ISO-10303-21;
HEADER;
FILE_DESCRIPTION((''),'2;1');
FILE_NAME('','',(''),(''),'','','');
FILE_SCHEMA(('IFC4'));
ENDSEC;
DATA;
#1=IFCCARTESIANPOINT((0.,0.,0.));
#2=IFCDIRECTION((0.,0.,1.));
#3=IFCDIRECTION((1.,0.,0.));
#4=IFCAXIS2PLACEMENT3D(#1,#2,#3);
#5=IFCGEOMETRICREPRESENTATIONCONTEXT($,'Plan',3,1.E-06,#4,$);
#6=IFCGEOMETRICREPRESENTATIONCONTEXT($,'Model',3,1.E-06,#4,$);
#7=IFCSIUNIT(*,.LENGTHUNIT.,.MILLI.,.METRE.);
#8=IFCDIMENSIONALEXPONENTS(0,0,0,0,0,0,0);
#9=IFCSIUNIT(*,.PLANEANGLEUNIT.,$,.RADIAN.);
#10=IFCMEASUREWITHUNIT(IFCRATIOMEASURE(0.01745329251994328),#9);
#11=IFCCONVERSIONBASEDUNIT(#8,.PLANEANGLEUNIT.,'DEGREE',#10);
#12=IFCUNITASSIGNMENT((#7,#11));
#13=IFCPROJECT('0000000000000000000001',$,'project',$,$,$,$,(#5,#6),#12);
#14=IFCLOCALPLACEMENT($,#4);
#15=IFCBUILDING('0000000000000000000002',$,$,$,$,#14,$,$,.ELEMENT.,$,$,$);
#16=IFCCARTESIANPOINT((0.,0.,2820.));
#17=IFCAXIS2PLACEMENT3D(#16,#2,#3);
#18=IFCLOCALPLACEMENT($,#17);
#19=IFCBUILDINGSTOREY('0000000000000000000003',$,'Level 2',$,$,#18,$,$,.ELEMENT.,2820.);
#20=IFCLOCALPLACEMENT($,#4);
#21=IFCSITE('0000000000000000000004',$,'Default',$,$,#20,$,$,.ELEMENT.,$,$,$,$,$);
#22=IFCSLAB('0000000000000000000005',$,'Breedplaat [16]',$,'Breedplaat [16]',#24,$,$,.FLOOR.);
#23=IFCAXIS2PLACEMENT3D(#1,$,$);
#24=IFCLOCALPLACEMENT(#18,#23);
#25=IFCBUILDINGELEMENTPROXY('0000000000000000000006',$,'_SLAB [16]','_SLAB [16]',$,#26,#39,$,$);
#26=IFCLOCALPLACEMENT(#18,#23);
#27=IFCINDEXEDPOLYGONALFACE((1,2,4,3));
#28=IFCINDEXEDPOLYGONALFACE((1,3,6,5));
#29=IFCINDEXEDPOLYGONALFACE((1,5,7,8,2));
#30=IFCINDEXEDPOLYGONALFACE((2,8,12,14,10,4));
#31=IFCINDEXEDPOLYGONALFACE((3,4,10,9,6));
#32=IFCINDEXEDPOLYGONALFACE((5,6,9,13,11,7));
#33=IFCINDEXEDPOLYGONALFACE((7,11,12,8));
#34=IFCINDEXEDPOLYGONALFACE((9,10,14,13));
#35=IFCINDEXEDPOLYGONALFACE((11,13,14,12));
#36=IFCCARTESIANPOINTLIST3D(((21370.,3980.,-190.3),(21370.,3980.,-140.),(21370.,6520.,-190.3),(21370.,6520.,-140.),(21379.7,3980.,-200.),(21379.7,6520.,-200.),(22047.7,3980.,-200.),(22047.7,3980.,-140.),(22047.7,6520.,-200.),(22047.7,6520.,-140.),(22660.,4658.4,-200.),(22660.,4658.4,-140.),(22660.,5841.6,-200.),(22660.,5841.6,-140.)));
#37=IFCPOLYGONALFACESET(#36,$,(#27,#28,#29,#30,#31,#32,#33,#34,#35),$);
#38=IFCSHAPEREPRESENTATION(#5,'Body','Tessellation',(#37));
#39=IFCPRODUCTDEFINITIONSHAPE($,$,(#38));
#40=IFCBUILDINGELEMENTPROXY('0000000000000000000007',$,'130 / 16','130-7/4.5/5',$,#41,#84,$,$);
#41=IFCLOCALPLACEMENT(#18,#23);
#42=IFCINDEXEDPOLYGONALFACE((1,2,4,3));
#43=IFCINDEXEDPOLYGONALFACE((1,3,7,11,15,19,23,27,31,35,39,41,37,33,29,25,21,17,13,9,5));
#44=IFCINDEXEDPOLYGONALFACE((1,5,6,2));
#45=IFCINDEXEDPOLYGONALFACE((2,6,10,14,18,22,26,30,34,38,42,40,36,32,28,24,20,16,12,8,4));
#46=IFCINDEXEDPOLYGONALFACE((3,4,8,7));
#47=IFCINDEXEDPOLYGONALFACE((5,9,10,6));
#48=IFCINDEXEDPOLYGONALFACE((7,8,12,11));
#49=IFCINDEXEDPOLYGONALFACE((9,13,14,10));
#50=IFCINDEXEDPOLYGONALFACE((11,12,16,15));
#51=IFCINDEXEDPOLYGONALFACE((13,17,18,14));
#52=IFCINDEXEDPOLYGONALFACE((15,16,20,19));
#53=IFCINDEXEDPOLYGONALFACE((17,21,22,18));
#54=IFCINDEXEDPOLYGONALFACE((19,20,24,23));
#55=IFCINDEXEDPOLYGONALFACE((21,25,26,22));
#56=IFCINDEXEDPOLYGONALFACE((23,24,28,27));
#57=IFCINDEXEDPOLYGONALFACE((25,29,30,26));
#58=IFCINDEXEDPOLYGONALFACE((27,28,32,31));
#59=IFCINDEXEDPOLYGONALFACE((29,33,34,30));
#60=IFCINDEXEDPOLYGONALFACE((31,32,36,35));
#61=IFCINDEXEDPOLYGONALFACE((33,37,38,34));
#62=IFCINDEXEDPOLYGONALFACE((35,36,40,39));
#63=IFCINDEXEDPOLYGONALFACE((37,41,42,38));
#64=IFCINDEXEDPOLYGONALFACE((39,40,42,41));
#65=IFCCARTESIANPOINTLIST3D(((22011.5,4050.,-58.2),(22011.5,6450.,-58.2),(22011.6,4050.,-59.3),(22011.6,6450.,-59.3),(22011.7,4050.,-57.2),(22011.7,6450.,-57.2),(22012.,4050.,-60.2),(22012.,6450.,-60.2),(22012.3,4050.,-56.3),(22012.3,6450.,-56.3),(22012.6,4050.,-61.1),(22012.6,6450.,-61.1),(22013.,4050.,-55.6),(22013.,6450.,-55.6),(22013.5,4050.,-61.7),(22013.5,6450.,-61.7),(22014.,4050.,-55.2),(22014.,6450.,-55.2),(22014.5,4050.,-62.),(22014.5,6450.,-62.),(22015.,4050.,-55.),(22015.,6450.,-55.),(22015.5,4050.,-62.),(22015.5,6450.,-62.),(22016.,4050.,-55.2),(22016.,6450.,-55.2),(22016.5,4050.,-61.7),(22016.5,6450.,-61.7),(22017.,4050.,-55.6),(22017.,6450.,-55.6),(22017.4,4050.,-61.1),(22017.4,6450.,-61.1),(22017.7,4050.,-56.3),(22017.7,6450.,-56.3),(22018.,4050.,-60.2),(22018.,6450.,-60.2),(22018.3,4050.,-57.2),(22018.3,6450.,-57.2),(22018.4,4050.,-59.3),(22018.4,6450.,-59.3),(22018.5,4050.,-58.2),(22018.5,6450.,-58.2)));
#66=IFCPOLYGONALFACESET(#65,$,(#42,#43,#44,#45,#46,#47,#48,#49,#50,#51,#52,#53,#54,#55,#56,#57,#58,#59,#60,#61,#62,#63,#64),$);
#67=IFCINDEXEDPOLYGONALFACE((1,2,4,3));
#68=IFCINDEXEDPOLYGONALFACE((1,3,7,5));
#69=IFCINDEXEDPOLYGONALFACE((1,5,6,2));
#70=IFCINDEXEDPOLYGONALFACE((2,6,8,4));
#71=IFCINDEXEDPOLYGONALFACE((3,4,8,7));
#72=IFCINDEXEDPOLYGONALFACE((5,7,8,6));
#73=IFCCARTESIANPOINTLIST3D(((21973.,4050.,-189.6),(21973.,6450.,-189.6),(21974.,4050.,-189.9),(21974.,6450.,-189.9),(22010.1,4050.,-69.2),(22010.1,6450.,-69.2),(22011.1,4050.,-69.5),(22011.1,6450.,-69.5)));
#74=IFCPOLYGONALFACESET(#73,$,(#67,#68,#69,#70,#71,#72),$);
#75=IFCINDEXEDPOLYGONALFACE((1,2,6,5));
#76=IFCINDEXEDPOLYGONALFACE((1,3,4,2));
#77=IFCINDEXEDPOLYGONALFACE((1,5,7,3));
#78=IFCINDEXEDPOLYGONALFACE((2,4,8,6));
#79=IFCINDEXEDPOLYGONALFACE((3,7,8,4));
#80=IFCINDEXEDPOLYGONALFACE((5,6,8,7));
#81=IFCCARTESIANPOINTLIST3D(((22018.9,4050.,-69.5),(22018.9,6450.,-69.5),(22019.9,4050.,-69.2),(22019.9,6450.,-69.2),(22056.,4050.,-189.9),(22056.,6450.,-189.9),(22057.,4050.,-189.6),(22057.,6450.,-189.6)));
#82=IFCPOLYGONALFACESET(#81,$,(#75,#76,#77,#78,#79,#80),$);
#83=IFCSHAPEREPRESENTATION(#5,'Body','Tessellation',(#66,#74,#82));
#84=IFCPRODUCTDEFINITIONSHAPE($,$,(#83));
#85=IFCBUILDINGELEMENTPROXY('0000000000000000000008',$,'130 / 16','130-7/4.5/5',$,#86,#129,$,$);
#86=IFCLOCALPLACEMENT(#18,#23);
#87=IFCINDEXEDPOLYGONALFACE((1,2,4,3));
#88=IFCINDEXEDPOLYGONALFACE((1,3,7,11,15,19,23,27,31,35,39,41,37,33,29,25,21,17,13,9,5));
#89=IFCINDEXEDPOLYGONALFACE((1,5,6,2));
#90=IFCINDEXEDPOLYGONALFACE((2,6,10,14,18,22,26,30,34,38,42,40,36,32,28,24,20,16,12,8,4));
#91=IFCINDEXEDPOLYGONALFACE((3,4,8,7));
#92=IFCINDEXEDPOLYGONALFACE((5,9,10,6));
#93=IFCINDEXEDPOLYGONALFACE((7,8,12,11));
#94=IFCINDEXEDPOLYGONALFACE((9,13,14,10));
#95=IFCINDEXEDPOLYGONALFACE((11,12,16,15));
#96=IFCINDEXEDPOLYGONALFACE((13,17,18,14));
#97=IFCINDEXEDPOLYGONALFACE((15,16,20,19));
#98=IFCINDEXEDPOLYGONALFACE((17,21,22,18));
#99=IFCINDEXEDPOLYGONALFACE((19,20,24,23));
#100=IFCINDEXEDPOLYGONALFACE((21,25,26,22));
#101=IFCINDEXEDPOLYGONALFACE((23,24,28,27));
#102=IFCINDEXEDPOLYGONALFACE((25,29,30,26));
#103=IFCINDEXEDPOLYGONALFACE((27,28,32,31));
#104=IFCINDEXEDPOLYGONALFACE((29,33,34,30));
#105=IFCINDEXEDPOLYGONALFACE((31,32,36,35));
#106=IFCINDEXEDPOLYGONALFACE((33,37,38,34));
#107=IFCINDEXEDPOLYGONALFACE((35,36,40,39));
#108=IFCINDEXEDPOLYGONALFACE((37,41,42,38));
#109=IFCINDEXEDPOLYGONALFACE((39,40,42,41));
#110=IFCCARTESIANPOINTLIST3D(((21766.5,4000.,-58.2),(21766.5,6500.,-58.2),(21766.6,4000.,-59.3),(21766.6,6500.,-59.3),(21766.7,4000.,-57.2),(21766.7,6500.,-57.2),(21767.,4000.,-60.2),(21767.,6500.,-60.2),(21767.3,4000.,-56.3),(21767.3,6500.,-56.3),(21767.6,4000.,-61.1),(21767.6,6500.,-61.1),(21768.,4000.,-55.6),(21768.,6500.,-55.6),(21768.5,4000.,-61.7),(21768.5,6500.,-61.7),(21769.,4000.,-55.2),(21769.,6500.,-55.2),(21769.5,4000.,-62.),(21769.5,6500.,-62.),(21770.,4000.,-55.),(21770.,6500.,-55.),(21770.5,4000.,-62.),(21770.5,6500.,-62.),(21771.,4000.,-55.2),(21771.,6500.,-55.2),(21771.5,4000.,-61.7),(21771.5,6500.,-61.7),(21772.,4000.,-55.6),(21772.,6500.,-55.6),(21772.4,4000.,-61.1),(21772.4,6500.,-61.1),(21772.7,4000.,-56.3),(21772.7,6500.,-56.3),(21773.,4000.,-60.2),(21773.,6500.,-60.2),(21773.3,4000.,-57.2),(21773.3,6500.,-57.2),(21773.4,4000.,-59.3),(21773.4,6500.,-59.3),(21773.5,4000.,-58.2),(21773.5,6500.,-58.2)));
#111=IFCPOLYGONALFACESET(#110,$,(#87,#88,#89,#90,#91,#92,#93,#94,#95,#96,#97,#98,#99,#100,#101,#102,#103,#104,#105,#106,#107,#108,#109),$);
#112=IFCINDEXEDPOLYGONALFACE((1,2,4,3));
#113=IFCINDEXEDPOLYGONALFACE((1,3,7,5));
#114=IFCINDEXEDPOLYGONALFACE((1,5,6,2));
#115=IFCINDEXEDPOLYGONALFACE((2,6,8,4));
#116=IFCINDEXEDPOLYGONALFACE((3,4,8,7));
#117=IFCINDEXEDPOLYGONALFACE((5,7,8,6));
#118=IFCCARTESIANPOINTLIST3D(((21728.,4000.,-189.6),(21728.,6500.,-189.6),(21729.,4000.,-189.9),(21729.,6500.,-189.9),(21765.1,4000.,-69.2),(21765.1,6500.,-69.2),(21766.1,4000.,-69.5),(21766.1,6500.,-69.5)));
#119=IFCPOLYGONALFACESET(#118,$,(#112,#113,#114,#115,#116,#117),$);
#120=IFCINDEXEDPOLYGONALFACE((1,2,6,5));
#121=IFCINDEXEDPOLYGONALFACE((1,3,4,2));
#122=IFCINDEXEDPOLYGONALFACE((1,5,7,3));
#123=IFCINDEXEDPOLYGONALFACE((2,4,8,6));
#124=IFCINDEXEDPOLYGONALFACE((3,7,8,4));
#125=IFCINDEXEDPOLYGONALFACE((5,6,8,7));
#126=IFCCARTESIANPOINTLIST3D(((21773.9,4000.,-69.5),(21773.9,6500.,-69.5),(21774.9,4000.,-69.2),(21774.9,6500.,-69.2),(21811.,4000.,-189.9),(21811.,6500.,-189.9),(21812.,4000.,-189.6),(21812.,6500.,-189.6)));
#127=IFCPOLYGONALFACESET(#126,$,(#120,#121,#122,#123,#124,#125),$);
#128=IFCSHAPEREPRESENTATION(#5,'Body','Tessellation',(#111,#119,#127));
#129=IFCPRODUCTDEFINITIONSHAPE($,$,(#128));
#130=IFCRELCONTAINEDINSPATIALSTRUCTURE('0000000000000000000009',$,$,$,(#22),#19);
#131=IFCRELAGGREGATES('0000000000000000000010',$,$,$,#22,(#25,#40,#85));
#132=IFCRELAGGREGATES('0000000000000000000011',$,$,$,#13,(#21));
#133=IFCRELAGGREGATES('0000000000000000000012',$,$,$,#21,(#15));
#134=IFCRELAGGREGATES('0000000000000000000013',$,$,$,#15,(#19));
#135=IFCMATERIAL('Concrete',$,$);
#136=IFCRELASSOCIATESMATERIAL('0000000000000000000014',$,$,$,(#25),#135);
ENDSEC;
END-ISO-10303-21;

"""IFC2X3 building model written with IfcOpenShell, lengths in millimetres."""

from ifc_helpers import new_model, entity, si_unit, converted_unit, frame, origin_with_axes, origin_2d_with_axis, place, context, project, spatial, polyline, rectangle, circle, outline, extrude, material, element, aggregate, save


model = new_model("IFC2X3")

# Units and contexts
plan_context = context("Plan", 3, precision=1e-06, world=origin_with_axes())
model_context = context("Model", 3, precision=1e-06, world=origin_with_axes())
ifc_project = project(units=[si_unit("LENGTHUNIT", "METRE", prefix="MILLI"), converted_unit("PLANEANGLEUNIT", "DEGREE", entity("IfcRatioMeasure", 0.01745329251994328), si_unit("PLANEANGLEUNIT", "RADIAN"), dimensions=[0, 0, 0, 0, 0, 0, 0])], contexts=[plan_context, model_context])

# Site, building, storey
site_placement = place(None, origin_with_axes())
site = spatial("IfcSite", under=ifc_project, at=site_placement, Name="Default", CompositionType="ELEMENT")
building_placement = place(None, origin_with_axes())
building = spatial("IfcBuilding", under=site, at=building_placement, CompositionType="ELEMENT")
storey_placement = place(None, frame((0.0, 0.0, 2820.0), z_axis=(0.0, 0.0, 1.0), x_axis=(1.0, 0.0, 0.0)))
storey = spatial("IfcBuildingStorey", under=building, at=storey_placement, Name="Level 2", CompositionType="ELEMENT", Elevation=2820.0)

# Slab, building element proxies, opening
slab_1_placement = place(None, frame((21370.0, 6520.0, 2620.0), z_axis=(0.0, 0.0, 1.0), x_axis=(0.0, -1.0, 0.0)))
slab_1 = element("IfcSlab", 1, at=slab_1_placement, inside=storey, Name="Breedplaat [16]", ObjectType="Breedplaat [16]", PredefinedType="FLOOR")
ifc_material = material(Name="Concrete")
proxy_1_placement = place(slab_1_placement, origin_with_axes())
proxy_1 = element("IfcBuildingElementProxy", 2, at=proxy_1_placement, material=ifc_material, Name="_SLAB [16]", Description="_SLAB [16]", context=plan_context, shape_type="SweptSolid", body=[
    extrude(outline(polyline([(1861.6, 1290.0), (678.4, 1290.0), (0.0, 677.8), (0.0, 0.0), (2540.0, 0.0), (2540.0, 677.8), (1861.6, 1290.0)])), origin_with_axes(), (0.0, 0.0, 1.0), 60.0),
])
opening_placement = place(None, frame((21370.0, 6520.0, 2620.0), z_axis=(0.0, 0.0, 1.0), x_axis=(0.0, -1.0, 0.0)))
element("IfcOpeningElement", 3, at=opening_placement, cuts=proxy_1, ObjectType="Opening", context=plan_context, shape_type="SweptSolid", body=[
    extrude(outline(polyline([(-0.1, -0.1), (-0.1, 10.0), (10.0, -0.1), (-0.1, -0.1)])), frame((-1.2, -0.1, -0.1), z_axis=(1.0, 0.0, 0.0), x_axis=(0.0, 1.0, 0.0)), (0.0, 0.0, 1.0), 2542.2),
])
proxy_2_placement = place(slab_1_placement, frame((70.0, 645.0, 15.0), z_axis=(0.0, 0.0, 1.0), x_axis=(1.0, 0.0, 0.0)))
proxy_2 = element("IfcBuildingElementProxy", 4, at=proxy_2_placement, Name="130 / 16", Description="130-7/4.5/5", context=plan_context, shape_type="SweptSolid", body=[
    extrude(circle(Radius=3.5, at=origin_2d_with_axis()), frame((0.0, 0.0, 126.5), z_axis=(1.0, 0.0, 0.0), x_axis=(0.0, 0.0, 1.0)), (0.0, 0.0, 1.0), 2400.0),
    extrude(rectangle(XDim=126.0, YDim=1.0, at=origin_2d_with_axis()), frame((0.0, -22.9, 55.4), z_axis=(1.0, 0.0, 0.0), x_axis=(0.0, 0.294086, 0.955779)), (0.0, 0.0, 1.0), 2400.0),
    extrude(rectangle(XDim=126.0, YDim=1.0, at=origin_2d_with_axis()), frame((0.0, 22.9, 55.4), z_axis=(1.0, 0.0, 0.0), x_axis=(0.0, -0.294086, 0.955779)), (0.0, 0.0, 1.0), 2400.0),
])
proxy_3_placement = place(slab_1_placement, frame((20.0, 400.0, 15.0), z_axis=(0.0, 0.0, 1.0), x_axis=(1.0, 0.0, 0.0)))
proxy_3 = element("IfcBuildingElementProxy", 5, at=proxy_3_placement, Name="130 / 16", Description="130-7/4.5/5", context=plan_context, shape_type="SweptSolid", body=[
    extrude(circle(Radius=3.5, at=origin_2d_with_axis()), frame((0.0, 0.0, 126.5), z_axis=(1.0, 0.0, 0.0), x_axis=(0.0, 0.0, 1.0)), (0.0, 0.0, 1.0), 2500.0),
    extrude(rectangle(XDim=126.0, YDim=1.0, at=origin_2d_with_axis()), frame((0.0, -22.9, 55.4), z_axis=(1.0, 0.0, 0.0), x_axis=(0.0, 0.294086, 0.955779)), (0.0, 0.0, 1.0), 2500.0),
    extrude(rectangle(XDim=126.0, YDim=1.0, at=origin_2d_with_axis()), frame((0.0, 22.9, 55.4), z_axis=(1.0, 0.0, 0.0), x_axis=(0.0, -0.294086, 0.955779)), (0.0, 0.0, 1.0), 2500.0),
])
aggregate(slab_1, [proxy_1, proxy_2, proxy_3])

save(model, "model.ifc")
